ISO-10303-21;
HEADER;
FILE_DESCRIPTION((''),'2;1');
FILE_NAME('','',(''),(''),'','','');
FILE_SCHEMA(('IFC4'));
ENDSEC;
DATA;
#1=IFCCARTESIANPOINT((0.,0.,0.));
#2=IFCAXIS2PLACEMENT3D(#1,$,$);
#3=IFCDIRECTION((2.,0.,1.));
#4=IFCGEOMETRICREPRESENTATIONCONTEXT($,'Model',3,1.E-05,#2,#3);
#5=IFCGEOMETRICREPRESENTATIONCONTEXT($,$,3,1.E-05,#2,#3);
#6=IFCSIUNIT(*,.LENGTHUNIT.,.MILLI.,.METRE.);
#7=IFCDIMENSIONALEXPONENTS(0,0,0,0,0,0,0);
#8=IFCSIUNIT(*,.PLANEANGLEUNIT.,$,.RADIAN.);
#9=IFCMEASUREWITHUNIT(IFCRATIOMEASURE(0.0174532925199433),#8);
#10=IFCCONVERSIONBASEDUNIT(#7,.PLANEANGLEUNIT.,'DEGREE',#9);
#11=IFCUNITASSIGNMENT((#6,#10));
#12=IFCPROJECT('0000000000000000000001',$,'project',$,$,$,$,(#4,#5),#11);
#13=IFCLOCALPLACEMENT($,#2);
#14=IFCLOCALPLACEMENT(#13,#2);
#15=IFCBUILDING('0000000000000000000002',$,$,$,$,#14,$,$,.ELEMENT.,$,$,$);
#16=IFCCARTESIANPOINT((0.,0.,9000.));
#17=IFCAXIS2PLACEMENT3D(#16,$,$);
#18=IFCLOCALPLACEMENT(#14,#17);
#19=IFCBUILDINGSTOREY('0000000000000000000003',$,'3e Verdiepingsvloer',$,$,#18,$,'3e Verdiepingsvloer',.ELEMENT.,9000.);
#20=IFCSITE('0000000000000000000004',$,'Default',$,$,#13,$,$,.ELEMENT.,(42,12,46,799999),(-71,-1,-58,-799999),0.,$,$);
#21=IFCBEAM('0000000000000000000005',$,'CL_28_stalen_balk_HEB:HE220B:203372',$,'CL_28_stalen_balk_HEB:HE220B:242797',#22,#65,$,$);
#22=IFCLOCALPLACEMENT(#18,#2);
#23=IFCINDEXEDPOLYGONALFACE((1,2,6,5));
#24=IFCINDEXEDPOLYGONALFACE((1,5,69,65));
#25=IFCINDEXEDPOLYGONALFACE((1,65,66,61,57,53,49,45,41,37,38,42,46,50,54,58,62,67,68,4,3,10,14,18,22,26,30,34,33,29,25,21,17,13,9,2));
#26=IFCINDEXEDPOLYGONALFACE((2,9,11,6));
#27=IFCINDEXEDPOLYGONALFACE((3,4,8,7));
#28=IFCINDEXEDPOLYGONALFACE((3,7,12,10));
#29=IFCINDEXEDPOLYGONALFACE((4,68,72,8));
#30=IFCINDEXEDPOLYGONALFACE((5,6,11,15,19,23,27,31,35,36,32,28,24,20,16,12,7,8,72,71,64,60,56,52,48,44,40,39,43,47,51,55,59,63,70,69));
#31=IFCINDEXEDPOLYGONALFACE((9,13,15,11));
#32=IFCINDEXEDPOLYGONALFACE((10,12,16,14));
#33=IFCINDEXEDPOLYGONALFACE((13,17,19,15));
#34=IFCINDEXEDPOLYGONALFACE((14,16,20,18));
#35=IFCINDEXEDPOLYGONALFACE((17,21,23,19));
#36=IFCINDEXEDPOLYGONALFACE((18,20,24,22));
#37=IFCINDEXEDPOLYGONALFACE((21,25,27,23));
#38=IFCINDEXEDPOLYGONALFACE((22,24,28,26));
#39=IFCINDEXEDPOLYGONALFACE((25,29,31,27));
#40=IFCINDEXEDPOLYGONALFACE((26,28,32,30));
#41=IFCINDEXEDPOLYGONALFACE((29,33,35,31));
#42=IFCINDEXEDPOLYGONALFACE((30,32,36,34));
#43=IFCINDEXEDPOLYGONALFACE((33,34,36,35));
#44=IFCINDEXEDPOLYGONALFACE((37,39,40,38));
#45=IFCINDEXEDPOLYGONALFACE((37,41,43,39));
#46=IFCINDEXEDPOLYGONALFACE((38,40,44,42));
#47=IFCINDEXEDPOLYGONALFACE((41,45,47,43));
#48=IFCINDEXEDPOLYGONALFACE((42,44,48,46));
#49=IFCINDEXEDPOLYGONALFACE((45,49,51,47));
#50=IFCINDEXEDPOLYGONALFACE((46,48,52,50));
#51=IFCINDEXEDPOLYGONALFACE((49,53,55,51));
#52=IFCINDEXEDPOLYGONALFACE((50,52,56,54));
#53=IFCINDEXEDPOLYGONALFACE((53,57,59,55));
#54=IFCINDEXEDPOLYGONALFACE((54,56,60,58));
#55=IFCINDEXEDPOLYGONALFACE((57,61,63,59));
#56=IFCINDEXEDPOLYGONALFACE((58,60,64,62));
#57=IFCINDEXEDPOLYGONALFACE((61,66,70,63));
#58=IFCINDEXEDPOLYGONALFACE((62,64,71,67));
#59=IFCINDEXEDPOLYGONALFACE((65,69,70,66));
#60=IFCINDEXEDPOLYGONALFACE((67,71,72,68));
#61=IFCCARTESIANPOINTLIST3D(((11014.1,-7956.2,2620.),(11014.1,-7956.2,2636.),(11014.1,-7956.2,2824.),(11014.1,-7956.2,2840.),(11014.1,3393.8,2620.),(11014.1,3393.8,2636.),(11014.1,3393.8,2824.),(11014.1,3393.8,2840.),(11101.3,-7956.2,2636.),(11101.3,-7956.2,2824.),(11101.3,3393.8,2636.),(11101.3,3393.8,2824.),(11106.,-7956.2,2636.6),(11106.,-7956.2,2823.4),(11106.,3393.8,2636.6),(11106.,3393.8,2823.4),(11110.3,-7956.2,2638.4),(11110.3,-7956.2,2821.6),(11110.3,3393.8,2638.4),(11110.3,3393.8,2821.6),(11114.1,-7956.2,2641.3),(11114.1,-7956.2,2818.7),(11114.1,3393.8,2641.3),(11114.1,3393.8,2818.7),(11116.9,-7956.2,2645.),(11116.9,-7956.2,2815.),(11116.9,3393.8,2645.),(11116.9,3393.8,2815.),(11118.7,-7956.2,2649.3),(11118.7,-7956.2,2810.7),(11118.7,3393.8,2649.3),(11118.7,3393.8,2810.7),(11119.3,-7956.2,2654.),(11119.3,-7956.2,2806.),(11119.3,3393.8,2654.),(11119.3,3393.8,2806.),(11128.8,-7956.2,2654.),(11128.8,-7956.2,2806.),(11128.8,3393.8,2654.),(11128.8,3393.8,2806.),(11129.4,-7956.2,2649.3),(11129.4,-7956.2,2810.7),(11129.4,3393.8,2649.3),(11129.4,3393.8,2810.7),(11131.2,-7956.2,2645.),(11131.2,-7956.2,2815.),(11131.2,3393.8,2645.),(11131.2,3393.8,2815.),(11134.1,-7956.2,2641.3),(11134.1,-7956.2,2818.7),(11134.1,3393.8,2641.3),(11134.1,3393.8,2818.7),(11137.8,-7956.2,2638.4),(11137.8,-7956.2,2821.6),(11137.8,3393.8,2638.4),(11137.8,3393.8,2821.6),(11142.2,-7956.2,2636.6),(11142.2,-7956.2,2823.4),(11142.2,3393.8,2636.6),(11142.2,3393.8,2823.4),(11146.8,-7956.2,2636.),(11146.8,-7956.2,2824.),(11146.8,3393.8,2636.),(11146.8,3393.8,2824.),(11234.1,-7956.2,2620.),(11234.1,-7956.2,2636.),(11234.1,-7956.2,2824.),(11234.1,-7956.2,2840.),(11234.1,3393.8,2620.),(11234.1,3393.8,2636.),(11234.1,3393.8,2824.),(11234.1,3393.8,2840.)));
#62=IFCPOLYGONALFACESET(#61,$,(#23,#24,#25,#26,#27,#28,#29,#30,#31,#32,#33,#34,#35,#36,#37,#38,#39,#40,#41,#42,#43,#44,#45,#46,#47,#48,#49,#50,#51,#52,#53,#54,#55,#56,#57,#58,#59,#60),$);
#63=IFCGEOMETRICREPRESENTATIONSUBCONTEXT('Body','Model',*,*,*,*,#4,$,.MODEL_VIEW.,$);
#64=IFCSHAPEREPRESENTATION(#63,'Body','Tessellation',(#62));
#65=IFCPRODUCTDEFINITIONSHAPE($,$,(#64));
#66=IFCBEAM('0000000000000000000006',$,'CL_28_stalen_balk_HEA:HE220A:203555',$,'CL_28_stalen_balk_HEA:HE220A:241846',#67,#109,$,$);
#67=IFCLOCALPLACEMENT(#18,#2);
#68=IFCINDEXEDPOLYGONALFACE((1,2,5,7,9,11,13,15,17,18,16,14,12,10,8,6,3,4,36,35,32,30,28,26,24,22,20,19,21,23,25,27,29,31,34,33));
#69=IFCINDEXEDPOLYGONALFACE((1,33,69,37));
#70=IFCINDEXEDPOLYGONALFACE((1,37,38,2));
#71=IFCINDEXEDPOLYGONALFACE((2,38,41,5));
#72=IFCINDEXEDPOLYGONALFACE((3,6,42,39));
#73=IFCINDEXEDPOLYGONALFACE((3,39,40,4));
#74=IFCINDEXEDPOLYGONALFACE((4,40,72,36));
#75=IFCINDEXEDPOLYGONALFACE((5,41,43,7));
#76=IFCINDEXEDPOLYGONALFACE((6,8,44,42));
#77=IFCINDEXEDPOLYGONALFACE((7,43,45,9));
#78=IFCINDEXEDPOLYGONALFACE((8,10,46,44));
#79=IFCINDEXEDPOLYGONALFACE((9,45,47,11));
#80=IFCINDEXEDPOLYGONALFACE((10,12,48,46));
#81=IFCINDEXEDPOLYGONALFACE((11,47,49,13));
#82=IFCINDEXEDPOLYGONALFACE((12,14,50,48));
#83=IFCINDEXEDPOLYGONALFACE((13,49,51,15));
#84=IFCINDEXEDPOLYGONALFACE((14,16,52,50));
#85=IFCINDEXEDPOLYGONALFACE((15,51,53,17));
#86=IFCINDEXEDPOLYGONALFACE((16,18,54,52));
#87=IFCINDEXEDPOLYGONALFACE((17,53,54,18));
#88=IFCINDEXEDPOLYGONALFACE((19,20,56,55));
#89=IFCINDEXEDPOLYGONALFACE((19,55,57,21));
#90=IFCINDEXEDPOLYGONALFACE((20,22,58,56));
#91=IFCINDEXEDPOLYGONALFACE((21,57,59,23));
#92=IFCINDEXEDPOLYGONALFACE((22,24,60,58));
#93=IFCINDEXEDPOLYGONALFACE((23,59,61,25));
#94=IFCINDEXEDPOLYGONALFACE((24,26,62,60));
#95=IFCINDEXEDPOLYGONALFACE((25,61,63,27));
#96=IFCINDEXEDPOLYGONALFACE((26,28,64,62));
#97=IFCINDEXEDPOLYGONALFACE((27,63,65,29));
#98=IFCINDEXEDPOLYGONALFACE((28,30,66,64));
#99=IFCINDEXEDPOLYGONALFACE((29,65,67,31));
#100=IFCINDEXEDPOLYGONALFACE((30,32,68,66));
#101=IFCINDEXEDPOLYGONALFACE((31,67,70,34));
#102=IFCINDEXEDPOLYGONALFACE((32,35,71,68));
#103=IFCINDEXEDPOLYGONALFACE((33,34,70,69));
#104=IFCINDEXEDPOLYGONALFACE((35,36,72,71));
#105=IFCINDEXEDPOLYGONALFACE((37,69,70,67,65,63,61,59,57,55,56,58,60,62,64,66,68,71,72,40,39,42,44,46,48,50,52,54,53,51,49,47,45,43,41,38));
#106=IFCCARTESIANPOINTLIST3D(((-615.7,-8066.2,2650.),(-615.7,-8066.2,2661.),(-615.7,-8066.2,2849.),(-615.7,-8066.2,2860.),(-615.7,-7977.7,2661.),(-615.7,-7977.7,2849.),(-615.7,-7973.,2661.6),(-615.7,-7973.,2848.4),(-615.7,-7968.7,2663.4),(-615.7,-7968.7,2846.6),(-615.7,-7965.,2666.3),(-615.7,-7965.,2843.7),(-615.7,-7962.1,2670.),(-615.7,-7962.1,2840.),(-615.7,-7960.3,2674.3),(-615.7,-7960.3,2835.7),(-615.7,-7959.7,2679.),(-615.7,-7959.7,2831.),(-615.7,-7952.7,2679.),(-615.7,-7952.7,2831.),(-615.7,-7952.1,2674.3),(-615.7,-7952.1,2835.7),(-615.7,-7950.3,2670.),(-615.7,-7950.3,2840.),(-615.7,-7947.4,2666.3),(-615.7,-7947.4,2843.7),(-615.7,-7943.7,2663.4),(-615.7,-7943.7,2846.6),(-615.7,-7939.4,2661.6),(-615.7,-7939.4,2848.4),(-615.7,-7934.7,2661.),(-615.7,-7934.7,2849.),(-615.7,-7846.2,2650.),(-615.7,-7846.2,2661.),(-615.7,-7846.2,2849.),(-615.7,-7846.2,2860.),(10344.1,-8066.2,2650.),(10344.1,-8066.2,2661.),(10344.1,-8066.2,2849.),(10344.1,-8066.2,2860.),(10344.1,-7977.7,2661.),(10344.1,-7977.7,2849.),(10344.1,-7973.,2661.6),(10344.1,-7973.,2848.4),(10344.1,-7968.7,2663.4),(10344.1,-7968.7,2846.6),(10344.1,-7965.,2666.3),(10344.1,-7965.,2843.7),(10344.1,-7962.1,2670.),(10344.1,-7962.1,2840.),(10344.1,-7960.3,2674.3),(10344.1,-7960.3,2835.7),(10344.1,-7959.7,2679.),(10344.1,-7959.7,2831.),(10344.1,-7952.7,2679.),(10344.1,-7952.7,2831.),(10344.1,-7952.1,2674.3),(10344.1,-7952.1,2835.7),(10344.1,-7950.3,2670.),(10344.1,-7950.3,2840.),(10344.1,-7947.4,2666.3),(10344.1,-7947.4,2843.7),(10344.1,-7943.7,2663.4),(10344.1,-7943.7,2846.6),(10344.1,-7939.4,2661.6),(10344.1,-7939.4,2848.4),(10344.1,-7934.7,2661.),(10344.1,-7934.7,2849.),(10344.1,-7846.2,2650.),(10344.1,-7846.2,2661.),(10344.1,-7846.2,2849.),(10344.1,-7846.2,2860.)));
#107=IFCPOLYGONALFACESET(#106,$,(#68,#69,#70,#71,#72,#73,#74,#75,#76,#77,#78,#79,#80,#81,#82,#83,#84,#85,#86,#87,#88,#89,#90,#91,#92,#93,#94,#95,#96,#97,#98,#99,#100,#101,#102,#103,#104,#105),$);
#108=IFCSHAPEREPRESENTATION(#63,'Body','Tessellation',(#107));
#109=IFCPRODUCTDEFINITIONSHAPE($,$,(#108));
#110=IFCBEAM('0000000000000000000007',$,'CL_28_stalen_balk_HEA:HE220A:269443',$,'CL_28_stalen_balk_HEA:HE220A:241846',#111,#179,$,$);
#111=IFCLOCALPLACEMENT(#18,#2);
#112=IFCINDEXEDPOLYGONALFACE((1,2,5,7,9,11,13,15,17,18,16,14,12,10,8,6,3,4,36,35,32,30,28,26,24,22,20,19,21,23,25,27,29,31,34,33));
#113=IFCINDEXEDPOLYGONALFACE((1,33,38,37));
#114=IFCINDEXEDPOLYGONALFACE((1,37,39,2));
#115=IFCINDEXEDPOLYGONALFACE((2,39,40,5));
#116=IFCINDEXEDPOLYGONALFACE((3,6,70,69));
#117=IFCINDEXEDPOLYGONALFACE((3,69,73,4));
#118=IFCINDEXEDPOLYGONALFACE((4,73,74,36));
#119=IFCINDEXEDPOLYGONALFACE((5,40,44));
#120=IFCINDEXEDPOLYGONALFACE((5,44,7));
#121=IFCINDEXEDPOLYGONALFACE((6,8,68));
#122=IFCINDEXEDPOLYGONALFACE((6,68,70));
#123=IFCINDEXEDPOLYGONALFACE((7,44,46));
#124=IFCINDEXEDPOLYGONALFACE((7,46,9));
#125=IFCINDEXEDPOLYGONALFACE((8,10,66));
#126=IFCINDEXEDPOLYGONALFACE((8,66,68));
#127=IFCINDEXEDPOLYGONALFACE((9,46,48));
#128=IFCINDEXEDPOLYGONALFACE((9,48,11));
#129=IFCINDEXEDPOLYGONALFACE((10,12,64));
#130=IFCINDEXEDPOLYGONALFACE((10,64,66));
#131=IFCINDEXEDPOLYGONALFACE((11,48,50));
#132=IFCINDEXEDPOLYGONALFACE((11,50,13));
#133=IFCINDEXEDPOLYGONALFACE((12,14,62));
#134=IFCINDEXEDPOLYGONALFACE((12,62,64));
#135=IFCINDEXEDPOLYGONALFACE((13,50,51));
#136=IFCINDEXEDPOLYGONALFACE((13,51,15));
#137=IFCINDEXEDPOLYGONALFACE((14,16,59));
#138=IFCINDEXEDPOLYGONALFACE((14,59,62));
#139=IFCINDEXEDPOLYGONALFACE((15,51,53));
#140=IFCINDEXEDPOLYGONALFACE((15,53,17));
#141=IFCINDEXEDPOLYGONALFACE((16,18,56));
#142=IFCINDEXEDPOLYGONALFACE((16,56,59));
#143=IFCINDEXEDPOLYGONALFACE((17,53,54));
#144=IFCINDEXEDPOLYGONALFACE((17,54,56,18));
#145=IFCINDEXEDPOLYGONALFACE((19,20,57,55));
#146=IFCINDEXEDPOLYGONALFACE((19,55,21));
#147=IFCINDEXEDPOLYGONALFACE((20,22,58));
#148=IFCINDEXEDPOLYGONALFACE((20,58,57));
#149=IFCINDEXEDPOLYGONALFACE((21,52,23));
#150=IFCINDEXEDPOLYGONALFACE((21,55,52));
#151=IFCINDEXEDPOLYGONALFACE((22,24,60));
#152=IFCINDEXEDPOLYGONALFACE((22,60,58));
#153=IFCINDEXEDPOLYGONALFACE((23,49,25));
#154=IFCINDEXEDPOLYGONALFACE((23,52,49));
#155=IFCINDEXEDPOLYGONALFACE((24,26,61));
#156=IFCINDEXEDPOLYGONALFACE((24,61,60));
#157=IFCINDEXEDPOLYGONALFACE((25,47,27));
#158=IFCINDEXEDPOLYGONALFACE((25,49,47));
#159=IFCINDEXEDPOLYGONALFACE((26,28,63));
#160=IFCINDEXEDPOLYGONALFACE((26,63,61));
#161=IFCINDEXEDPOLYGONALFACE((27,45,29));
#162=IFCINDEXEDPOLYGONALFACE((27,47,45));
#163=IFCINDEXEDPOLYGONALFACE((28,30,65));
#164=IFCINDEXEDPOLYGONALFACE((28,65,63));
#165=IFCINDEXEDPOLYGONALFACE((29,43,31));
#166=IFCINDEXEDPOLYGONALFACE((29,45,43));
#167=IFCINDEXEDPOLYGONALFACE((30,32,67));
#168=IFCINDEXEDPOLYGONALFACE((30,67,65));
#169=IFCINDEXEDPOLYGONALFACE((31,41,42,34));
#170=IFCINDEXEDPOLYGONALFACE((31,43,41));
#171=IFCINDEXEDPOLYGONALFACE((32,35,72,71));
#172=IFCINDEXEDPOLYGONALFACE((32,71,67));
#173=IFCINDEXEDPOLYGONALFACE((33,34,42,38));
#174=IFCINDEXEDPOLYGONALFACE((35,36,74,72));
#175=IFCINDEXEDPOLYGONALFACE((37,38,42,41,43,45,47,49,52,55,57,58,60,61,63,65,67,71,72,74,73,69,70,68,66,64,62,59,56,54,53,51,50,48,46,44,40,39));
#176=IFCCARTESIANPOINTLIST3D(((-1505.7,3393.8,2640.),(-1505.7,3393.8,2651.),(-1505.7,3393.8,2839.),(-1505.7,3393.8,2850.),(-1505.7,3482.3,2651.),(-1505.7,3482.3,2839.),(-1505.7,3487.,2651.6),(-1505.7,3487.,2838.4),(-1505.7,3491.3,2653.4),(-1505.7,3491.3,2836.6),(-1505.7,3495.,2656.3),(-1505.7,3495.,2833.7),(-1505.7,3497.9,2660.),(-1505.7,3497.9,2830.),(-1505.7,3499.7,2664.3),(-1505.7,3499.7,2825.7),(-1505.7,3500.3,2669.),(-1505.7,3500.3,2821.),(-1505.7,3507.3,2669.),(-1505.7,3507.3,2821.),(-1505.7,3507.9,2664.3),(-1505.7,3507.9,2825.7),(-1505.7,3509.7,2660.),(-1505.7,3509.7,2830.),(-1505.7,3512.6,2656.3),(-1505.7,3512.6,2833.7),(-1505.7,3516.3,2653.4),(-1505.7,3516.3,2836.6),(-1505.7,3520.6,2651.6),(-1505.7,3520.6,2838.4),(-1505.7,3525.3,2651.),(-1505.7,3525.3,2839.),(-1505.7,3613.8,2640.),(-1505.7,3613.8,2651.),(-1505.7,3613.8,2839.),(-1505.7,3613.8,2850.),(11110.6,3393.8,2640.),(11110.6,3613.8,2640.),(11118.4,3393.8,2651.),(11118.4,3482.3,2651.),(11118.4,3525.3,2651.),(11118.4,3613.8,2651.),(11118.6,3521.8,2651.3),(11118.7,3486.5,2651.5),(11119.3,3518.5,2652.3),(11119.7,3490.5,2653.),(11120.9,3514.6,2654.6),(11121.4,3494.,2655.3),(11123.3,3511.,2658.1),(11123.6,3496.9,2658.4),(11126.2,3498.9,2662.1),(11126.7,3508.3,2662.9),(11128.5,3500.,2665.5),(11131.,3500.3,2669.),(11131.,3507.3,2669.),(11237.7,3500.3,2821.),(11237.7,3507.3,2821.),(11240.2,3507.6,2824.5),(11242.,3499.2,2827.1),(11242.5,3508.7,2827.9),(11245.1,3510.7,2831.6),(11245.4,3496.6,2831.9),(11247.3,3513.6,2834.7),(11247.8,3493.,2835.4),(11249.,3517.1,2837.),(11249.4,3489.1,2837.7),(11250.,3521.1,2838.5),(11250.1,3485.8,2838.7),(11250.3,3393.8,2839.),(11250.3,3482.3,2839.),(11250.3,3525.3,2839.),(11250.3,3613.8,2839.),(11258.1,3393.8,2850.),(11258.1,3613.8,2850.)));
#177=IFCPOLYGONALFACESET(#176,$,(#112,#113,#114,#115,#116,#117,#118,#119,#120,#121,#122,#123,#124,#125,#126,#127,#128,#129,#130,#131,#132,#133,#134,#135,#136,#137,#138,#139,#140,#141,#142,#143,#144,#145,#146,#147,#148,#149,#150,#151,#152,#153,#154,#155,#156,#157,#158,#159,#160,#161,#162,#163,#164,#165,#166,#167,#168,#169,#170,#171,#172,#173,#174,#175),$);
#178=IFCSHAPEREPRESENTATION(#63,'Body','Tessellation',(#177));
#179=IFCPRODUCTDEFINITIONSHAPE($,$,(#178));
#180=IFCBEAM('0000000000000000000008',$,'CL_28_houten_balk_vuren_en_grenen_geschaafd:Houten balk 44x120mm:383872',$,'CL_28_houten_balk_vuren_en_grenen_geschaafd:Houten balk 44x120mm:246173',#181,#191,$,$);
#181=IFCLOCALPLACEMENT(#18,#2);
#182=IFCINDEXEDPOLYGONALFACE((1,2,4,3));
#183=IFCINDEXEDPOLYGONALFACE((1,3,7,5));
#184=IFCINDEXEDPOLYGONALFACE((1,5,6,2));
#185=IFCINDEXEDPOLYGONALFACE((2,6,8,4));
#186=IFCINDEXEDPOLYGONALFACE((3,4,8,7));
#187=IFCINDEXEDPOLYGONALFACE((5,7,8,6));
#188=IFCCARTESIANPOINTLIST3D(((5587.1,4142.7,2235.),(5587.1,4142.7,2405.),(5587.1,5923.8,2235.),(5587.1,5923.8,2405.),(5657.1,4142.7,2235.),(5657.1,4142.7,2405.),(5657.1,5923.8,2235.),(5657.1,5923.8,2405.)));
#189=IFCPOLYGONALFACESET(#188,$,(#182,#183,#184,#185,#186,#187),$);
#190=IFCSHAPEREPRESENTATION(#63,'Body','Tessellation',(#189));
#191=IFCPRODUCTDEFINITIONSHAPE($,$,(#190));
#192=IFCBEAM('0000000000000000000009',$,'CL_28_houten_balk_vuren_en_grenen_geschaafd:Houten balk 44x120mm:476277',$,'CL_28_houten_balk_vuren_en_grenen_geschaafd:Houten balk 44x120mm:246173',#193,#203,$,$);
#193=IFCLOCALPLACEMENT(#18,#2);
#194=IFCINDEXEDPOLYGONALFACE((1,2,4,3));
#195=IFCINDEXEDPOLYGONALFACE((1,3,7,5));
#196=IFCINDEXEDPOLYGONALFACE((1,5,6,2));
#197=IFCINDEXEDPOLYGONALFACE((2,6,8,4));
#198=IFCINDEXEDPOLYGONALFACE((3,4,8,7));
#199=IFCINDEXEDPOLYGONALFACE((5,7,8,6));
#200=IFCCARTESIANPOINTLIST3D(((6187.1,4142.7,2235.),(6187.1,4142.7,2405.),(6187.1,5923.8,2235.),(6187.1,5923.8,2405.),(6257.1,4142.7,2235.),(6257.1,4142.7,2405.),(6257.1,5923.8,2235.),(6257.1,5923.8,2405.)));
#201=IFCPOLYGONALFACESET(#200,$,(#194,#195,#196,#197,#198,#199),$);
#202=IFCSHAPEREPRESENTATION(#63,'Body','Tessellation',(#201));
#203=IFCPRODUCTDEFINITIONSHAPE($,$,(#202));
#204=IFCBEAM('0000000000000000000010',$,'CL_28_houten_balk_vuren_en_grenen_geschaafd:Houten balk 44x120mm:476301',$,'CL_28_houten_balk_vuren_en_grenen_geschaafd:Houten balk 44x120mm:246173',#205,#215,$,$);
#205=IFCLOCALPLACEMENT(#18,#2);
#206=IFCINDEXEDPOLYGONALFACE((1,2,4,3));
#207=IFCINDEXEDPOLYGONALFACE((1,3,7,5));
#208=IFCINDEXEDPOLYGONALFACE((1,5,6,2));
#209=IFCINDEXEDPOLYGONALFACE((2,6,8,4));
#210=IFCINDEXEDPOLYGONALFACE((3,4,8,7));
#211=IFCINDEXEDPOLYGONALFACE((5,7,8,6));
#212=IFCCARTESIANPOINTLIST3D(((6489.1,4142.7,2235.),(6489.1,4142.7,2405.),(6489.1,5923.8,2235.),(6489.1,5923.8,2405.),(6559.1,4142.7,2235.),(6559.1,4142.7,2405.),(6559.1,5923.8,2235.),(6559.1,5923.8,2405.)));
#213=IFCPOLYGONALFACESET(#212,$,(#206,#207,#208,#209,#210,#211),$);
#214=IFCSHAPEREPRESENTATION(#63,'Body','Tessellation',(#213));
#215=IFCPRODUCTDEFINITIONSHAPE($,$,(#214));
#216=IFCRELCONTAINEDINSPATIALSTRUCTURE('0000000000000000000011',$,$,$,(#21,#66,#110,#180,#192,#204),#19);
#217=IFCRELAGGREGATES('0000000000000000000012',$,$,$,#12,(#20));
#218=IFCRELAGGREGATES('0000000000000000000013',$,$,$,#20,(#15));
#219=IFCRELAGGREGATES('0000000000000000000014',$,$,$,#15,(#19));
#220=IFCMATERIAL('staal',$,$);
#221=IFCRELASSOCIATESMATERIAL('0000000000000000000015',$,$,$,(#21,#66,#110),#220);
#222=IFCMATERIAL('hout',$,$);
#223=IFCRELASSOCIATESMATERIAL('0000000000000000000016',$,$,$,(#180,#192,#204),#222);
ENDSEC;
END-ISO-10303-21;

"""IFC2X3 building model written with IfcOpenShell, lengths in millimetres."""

from ifc_helpers import new_model, entity, si_unit, converted_unit, direction, frame, frame_2d, origin, place, context, subcontext, project, spatial, rectangle, i_section, extrude, clip, halfspace, material, element, save


model = new_model("IFC2X3")

# Units and contexts
model_context = context("Model", 3, precision=1e-05, world=origin(), true_north=direction((2.0, 0.0, 1.0)))
context_of_model = context(None, 3, precision=1e-05, world=origin(), true_north=direction((2.0, 0.0, 1.0)))
body_context = subcontext(model_context, "Body", "Model", "MODEL_VIEW")
ifc_project = project(units=[si_unit("LENGTHUNIT", "METRE", prefix="MILLI"), converted_unit("PLANEANGLEUNIT", "DEGREE", entity("IfcRatioMeasure", 0.0174532925199433), si_unit("PLANEANGLEUNIT", "RADIAN"), dimensions=[0, 0, 0, 0, 0, 0, 0])], contexts=[model_context, context_of_model])

# Site, building, storey
site_placement = place(None, origin())
site = spatial("IfcSite", under=ifc_project, at=site_placement, Name="Default", CompositionType="ELEMENT", RefLatitude=(42, 12, 46, 799999), RefLongitude=(-71, -1, -58, -799999), RefElevation=0.0)
building_placement = place(site_placement, origin())
building = spatial("IfcBuilding", under=site, at=building_placement, CompositionType="ELEMENT")
storey_placement = place(building_placement, frame((0.0, 0.0, 9000.0)))
storey = spatial("IfcBuildingStorey", under=building, at=storey_placement, Name="3e Verdiepingsvloer", LongName="3e Verdiepingsvloer", CompositionType="ELEMENT", Elevation=9000.0)

# Beams
ifc_material_1 = material(Name="staal")
beam_1_placement = place(storey_placement, frame((11124.1, -7956.2, 2840.0), z_axis=(0.0, 0.0, 1.0), x_axis=(0.0, 1.0, 0.0)))
element("IfcBeam", 1, at=beam_1_placement, inside=storey, material=ifc_material_1, Name="CL_28_stalen_balk_HEB:HE220B:203372", ObjectType="CL_28_stalen_balk_HEB:HE220B:242797", context=body_context, shape_type="SweptSolid", body=[
    extrude(i_section(OverallWidth=220.0, OverallDepth=220.0, WebThickness=9.5, FlangeThickness=16.0, FilletRadius=18.0, at=frame_2d((0.0, 0.0), x_axis=(0.0, 1.0))), frame((0.0, 0.0, -110.0), z_axis=(1.0, 0.0, 0.0), x_axis=(0.0, 0.0, -1.0)), (0.0, 0.0, 1.0), 11350.0),
])
beam_2_placement = place(storey_placement, frame((10764.1, -7956.2, 2860.0), z_axis=(0.0, 0.0, 1.0), x_axis=(-1.0, 0.0, 0.0)))
element("IfcBeam", 2, at=beam_2_placement, inside=storey, material=ifc_material_1, Name="CL_28_stalen_balk_HEA:HE220A:203555", ObjectType="CL_28_stalen_balk_HEA:HE220A:241846", context=body_context, shape_type="SweptSolid", body=[
    extrude(i_section(OverallWidth=220.0, OverallDepth=210.0, WebThickness=7.0, FlangeThickness=11.0, FilletRadius=18.0, at=frame_2d((0.0, 0.0), x_axis=(0.0, 1.0))), frame((420.0, 0.0, -105.0), z_axis=(1.0, 0.0, 0.0), x_axis=(0.0, 0.0, -1.0)), (0.0, 0.0, 1.0), 10959.8),
])
beam_3_placement = place(storey_placement, frame((11704.1, 3503.8, 2850.0), z_axis=(0.0, 0.0, 1.0), x_axis=(-1.0, 0.0, 0.0)))
element("IfcBeam", 3, at=beam_3_placement, inside=storey, material=ifc_material_1, Name="CL_28_stalen_balk_HEA:HE220A:269443", ObjectType="CL_28_stalen_balk_HEA:HE220A:241846", context=body_context, shape_type="Clipping", body=[
    clip(extrude(i_section(OverallWidth=220.0, OverallDepth=210.0, WebThickness=7.0, FlangeThickness=11.0, FilletRadius=18.0, at=frame_2d((0.0, 0.0), x_axis=(0.0, 1.0))), frame((446.0, 0.0, -105.0), z_axis=(1.0, 0.0, 0.0), x_axis=(0.0, 0.0, -1.0)), (0.0, 0.0, 1.0), 12763.8), halfspace(frame((446.0, -2115.1, 0.0), z_axis=(-0.818469, 0.0, -0.574551), x_axis=(-0.574551, 0.0, 0.818469)), False)),
])
ifc_material_2 = material(Name="hout")
for number, where, z_axis, x_axis, name in (
    (4, (5622.1, 4142.7, 2405.0), (0.0, 0.0, 1.0), (0.0, 1.0, 0.0), "CL_28_houten_balk_vuren_en_grenen_geschaafd:Houten balk 44x120mm:383872"),
    (5, (6222.1, 4142.7, 2405.0), (0.0, 0.0, 1.0), (0.0, 1.0, 0.0), "CL_28_houten_balk_vuren_en_grenen_geschaafd:Houten balk 44x120mm:476277"),
):
    element("IfcBeam", number, at=place(storey_placement, frame(where, z_axis=z_axis, x_axis=x_axis)), inside=storey, material=ifc_material_2, Name=name, ObjectType="CL_28_houten_balk_vuren_en_grenen_geschaafd:Houten balk 44x120mm:246173", context=body_context, shape_type="SweptSolid", body=[
        extrude(rectangle(XDim=170.0, YDim=70.0, at=frame_2d((0.0, 0.0), x_axis=(1.0, 0.0))), frame((0.0, 0.0, -85.0), z_axis=(1.0, 0.0, 0.0), x_axis=(0.0, 0.0, -1.0)), (0.0, 0.0, 1.0), 1781.1),
    ])
beam_4_placement = place(storey_placement, frame((6524.1, 4142.7, 2405.0), z_axis=(0.0, 0.0, 1.0), x_axis=(0.0, 1.0, 0.0)))
element("IfcBeam", 6, at=beam_4_placement, inside=storey, material=ifc_material_2, Name="CL_28_houten_balk_vuren_en_grenen_geschaafd:Houten balk 44x120mm:476301", ObjectType="CL_28_houten_balk_vuren_en_grenen_geschaafd:Houten balk 44x120mm:246173", context=body_context, shape_type="SweptSolid", body=[
    extrude(rectangle(XDim=170.0, YDim=70.0, at=frame_2d((0.0, 0.0), x_axis=(1.0, 0.0))), frame((0.0, 0.0, -85.0), z_axis=(1.0, 0.0, 0.0), x_axis=(0.0, 0.0, -1.0)), (0.0, 0.0, 1.0), 1781.1),
])

save(model, "model.ifc")
